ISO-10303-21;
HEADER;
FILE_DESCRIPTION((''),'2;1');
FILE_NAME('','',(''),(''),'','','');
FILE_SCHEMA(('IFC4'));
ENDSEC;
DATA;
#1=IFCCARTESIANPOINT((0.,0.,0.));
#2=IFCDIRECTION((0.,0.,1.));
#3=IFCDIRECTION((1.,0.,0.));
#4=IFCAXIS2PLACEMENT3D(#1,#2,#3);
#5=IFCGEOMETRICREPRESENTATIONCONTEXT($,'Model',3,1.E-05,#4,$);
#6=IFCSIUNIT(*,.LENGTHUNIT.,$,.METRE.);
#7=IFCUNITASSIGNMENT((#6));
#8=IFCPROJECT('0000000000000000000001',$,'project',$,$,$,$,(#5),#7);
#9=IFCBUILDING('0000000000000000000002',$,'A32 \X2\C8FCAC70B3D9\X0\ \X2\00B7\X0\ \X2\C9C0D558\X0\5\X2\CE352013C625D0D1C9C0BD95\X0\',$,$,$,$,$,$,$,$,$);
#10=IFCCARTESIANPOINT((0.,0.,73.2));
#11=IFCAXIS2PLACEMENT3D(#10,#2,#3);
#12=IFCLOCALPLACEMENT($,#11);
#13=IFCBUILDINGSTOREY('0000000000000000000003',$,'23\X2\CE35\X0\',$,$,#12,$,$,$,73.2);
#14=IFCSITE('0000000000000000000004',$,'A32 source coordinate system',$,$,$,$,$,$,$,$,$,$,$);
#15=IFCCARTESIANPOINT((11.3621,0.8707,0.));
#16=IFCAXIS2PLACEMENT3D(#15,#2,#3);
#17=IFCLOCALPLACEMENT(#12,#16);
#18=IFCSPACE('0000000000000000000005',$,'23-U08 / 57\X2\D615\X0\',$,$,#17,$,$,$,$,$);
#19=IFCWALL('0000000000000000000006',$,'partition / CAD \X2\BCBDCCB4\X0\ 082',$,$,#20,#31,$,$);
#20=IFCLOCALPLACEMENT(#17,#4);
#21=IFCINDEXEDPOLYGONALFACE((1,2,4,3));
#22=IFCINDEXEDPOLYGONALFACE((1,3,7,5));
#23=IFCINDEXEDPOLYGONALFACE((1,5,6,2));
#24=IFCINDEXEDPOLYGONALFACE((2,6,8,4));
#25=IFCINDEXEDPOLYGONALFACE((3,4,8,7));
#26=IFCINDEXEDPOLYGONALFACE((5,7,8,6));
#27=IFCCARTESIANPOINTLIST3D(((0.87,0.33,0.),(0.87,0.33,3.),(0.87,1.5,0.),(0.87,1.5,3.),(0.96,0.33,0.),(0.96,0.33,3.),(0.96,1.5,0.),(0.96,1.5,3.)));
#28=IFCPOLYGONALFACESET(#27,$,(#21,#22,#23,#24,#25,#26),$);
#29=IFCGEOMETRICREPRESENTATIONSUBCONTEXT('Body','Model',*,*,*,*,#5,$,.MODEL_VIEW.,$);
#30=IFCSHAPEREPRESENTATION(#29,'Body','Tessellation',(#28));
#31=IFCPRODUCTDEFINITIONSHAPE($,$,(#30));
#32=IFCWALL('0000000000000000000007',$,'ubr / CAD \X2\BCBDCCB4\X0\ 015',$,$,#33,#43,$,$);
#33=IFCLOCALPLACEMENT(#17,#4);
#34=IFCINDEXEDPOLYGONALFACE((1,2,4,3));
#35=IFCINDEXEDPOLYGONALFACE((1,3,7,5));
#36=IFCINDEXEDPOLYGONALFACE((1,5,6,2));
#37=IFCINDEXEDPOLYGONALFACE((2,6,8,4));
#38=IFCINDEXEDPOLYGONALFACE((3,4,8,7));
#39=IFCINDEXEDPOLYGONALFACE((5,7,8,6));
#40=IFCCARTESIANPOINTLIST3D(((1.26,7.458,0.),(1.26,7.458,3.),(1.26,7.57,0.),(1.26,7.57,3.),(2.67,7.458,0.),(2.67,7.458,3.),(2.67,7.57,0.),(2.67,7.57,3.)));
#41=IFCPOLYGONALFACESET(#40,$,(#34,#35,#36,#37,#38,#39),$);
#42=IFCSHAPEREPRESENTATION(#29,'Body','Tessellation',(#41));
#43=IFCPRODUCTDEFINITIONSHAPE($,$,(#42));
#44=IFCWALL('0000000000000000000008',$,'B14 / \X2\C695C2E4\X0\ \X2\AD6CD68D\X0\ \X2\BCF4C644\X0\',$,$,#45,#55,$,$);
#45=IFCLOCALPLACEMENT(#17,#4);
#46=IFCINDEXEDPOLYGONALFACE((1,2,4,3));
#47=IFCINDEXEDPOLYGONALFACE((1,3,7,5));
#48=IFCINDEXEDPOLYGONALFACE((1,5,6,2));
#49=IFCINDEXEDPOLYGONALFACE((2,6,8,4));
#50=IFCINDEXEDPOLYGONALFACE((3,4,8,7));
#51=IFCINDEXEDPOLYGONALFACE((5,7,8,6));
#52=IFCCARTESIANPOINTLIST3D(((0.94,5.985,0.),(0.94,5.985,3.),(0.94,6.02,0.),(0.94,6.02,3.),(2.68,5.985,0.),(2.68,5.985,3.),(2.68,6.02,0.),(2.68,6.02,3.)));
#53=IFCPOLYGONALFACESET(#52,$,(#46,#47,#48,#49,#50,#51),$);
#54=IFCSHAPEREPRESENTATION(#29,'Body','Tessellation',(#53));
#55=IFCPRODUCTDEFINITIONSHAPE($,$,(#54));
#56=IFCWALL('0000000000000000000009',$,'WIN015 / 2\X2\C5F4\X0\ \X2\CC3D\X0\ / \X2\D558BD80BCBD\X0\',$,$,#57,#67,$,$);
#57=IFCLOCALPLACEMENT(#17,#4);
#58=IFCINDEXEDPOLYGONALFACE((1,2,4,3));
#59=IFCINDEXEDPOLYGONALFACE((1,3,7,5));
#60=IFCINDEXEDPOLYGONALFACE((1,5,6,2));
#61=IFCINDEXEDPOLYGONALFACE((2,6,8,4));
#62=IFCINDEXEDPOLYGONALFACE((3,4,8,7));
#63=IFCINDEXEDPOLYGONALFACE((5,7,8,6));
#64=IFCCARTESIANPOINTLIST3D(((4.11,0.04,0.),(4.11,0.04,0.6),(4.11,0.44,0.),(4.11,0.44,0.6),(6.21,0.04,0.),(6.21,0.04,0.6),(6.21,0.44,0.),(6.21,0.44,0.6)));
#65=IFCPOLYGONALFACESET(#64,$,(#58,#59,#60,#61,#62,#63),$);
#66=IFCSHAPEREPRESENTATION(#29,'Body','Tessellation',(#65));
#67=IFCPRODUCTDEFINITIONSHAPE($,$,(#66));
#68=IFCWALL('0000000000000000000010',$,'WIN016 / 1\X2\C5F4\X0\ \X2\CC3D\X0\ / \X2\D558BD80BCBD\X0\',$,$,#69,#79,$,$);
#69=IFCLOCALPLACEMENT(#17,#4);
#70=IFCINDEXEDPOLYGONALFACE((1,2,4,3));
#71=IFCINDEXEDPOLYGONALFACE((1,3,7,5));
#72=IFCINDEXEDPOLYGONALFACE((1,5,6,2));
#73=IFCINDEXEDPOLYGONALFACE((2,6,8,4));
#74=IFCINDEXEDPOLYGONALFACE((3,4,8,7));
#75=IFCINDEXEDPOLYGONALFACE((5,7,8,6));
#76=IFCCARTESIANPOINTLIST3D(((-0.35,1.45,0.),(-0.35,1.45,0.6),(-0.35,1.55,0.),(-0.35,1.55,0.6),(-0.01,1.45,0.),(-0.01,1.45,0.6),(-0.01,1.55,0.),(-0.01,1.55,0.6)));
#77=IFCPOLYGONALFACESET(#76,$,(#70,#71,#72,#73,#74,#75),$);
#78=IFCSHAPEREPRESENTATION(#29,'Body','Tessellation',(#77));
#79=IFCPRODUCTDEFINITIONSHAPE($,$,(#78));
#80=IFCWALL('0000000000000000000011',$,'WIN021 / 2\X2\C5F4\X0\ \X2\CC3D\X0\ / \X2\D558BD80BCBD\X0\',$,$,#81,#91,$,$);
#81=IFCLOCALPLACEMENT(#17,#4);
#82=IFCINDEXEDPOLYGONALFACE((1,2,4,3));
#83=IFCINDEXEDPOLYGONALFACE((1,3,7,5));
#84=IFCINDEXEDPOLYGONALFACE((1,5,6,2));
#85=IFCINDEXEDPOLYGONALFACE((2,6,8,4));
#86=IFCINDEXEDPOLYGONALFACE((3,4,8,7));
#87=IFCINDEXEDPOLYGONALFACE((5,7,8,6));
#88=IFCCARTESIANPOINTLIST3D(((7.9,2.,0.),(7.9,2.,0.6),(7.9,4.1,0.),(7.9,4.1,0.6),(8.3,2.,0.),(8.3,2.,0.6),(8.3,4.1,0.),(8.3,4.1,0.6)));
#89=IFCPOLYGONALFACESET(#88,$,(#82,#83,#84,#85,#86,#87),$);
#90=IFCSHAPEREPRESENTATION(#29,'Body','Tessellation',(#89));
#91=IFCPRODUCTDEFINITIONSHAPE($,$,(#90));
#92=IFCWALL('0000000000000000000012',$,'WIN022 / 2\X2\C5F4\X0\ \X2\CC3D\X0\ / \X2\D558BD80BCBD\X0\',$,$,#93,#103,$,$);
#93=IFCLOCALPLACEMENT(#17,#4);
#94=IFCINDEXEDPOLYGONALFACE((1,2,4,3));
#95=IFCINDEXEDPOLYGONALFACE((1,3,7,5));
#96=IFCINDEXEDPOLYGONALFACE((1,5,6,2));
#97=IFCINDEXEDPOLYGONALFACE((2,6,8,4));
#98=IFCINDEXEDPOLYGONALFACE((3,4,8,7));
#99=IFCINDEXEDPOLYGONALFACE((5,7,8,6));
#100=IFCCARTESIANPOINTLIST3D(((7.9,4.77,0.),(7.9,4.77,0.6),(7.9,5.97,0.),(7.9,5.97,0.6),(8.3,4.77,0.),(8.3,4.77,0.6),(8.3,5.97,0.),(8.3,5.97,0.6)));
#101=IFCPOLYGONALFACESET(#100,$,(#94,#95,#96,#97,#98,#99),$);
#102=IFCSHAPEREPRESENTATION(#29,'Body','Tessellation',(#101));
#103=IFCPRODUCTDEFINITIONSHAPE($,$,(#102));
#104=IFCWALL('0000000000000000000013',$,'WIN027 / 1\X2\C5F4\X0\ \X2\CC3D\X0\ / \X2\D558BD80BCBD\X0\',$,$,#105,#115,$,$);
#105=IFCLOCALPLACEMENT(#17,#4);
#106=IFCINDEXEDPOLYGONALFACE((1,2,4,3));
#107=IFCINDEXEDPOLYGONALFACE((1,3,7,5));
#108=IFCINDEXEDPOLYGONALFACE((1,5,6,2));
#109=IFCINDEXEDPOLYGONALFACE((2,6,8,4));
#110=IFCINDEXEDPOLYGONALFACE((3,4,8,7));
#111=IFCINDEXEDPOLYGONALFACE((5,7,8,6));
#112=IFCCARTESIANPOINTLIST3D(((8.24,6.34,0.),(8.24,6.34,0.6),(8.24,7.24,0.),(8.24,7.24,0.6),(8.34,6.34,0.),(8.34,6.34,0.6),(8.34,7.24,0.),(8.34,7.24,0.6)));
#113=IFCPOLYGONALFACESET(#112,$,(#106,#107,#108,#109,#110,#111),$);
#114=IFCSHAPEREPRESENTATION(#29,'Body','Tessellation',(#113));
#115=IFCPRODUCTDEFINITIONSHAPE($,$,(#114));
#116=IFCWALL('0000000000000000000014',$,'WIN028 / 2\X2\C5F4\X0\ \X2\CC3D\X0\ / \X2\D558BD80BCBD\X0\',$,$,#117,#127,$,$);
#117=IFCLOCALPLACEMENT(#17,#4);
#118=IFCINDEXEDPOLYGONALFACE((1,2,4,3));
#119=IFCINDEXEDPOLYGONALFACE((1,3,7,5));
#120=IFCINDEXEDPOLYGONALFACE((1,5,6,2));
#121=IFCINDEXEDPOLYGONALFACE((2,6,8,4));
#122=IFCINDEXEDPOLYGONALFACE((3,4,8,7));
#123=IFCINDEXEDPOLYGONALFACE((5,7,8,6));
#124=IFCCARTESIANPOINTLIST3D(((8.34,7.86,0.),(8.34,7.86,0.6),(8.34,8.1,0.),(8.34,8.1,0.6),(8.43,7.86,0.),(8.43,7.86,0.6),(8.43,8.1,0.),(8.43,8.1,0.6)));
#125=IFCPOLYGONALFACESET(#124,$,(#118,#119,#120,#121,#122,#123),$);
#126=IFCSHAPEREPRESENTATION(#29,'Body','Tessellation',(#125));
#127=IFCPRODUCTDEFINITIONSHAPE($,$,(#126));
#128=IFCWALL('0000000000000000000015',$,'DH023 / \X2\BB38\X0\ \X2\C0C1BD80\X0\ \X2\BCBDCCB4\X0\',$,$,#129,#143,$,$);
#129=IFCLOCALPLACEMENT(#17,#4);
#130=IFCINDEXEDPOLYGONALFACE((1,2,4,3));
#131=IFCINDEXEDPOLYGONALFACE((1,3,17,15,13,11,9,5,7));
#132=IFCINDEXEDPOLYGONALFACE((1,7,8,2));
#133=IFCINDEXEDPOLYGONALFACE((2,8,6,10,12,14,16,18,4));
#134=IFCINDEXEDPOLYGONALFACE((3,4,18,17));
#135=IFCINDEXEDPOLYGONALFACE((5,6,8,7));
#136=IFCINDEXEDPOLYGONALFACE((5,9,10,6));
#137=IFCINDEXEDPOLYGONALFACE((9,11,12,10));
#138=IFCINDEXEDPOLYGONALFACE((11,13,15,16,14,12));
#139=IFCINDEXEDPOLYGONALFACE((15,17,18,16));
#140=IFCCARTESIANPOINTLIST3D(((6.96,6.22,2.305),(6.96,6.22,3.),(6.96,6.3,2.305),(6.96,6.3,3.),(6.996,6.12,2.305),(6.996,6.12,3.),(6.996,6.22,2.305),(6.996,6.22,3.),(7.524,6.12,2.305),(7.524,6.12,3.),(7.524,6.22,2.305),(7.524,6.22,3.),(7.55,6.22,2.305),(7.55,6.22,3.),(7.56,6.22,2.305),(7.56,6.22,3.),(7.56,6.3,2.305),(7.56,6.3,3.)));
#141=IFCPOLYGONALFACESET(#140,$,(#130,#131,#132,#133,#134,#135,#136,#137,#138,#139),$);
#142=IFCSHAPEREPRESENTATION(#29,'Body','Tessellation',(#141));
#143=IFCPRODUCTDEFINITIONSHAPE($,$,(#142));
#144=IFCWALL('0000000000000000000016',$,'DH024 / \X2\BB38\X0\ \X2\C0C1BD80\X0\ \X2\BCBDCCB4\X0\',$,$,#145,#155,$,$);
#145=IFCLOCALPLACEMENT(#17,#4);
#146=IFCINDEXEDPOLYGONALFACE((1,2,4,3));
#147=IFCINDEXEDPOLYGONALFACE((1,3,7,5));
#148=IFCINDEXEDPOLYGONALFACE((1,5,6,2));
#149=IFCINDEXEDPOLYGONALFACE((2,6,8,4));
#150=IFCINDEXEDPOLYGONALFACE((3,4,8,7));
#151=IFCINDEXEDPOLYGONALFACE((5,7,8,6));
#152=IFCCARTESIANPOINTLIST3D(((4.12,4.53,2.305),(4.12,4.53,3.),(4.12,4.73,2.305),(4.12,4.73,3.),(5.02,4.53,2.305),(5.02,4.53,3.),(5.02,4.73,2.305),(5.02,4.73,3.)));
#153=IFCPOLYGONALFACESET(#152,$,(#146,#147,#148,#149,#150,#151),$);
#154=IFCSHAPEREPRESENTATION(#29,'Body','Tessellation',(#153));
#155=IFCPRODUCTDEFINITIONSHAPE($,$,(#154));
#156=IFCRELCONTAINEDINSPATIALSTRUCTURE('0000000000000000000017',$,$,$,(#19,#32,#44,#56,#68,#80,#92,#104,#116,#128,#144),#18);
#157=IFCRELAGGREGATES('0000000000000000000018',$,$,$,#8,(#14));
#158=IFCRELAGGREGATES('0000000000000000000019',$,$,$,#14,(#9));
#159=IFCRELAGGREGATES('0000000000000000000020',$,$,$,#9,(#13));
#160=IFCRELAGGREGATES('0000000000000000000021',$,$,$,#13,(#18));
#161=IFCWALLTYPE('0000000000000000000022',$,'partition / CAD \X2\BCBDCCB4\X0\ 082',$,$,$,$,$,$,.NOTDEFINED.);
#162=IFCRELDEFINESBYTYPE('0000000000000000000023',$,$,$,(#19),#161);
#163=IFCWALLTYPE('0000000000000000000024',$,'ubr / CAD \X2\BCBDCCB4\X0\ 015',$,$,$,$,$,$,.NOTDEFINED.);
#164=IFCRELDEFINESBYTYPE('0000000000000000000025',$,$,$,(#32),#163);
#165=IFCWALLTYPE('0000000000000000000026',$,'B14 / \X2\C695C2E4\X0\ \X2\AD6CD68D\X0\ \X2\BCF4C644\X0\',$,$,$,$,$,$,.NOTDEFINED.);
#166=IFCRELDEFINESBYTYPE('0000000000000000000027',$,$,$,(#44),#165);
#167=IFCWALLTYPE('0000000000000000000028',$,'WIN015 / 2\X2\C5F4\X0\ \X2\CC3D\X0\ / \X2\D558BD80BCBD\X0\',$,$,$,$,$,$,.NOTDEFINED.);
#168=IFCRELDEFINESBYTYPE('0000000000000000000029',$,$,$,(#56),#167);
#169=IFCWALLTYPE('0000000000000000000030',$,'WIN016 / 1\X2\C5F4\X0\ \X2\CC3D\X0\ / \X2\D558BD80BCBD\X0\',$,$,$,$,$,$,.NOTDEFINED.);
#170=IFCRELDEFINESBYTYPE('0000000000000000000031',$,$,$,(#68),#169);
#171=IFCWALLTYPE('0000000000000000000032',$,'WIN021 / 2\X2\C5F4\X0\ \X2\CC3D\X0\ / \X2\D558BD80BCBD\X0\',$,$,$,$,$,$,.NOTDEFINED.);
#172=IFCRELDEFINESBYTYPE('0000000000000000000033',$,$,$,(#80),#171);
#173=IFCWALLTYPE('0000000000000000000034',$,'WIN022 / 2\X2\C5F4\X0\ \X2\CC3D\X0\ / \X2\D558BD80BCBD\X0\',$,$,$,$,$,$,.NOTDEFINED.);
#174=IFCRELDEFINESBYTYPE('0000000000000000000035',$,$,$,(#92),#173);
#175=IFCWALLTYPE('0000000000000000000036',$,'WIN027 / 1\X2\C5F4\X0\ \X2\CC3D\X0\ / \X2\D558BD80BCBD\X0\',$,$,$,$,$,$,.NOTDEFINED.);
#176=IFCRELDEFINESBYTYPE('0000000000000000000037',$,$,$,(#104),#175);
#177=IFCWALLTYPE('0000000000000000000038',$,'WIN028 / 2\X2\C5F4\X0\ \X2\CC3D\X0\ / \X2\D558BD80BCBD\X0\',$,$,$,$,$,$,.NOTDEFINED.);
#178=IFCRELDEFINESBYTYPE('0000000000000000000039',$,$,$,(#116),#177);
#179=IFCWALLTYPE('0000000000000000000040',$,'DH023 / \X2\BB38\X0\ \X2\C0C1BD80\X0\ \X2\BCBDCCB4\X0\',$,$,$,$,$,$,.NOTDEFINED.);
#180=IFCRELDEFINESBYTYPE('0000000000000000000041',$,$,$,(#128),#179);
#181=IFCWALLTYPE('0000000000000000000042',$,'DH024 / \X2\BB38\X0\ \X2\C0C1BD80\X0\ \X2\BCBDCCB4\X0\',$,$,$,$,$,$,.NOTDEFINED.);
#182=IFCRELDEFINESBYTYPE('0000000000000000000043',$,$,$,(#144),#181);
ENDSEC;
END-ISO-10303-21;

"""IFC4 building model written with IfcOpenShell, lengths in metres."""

from ifc_helpers import new_model, si_unit, frame, origin, origin_with_axes, place, context, subcontext, project, spatial, polyline, outline, extrude, source, transform, mapped, type_object, type_shapes, element, save


model = new_model("IFC4")

# Units and contexts
model_context = context("Model", 3, precision=1e-05, world=origin_with_axes())
body_context = subcontext(model_context, "Body", "Model", "MODEL_VIEW")
ifc_project = project(units=[si_unit("LENGTHUNIT", "METRE")], contexts=[model_context])

# Site, building, storey, space
site = spatial("IfcSite", under=ifc_project, Name="A32 source coordinate system")
building = spatial("IfcBuilding", under=site, Name="A32 주거동 · 지하5층–옥탑지붕")
storey_placement = place(None, frame((0.0, 0.0, 73.2), z_axis=(0.0, 0.0, 1.0), x_axis=(1.0, 0.0, 0.0)))
storey = spatial("IfcBuildingStorey", under=building, at=storey_placement, Name="23층", Elevation=73.2)
space_placement = place(storey_placement, frame((11.3621, 0.8707, 0.0), z_axis=(0.0, 0.0, 1.0), x_axis=(1.0, 0.0, 0.0)))
space = spatial("IfcSpace", under=storey, at=space_placement, Name="23-U08 / 57형")

# Walls
wall_type_1 = type_object("IfcWallType", Name="partition / CAD 벽체 082", PredefinedType="NOTDEFINED")
shared_shape_1 = source(origin(), body_context, "Body", "SweptSolid", [
    extrude(outline(polyline([(0.96, 0.33), (0.87, 0.33), (0.87, 1.5), (0.96, 1.5), (0.96, 0.33)])), origin(), (0.0, 0.0, 1.0), 3.0),
])
type_shapes(wall_type_1, [shared_shape_1])
wall_1_placement = place(space_placement, origin_with_axes())
element("IfcWall", 1, at=wall_1_placement, inside=space, type_object=wall_type_1, Name="partition / CAD 벽체 082", context=body_context, shape_type="MappedRepresentation", body=[
    mapped(shared_shape_1, transform((0.0, 0.0, 0.0), scale=1.0)),
])
wall_type_2 = type_object("IfcWallType", Name="ubr / CAD 벽체 015", PredefinedType="NOTDEFINED")
shared_shape_2 = source(origin(), body_context, "Body", "SweptSolid", [
    extrude(outline(polyline([(2.67, 7.57), (2.67, 7.458), (1.26, 7.458), (1.26, 7.57), (2.67, 7.57)])), origin(), (0.0, 0.0, 1.0), 3.0),
])
type_shapes(wall_type_2, [shared_shape_2])
wall_2_placement = place(space_placement, origin_with_axes())
element("IfcWall", 2, at=wall_2_placement, inside=space, type_object=wall_type_2, Name="ubr / CAD 벽체 015", context=body_context, shape_type="MappedRepresentation", body=[
    mapped(shared_shape_2, transform((0.0, 0.0, 0.0), scale=1.0)),
])
wall_type_3 = type_object("IfcWallType", Name="B14 / 욕실 구획 보완", PredefinedType="NOTDEFINED")
shared_shape_3 = source(origin(), body_context, "Body", "SweptSolid", [
    extrude(outline(polyline([(2.68, 5.985), (0.94, 5.985), (0.94, 6.02), (2.68, 6.02), (2.68, 5.985)])), origin(), (0.0, 0.0, 1.0), 3.0),
])
type_shapes(wall_type_3, [shared_shape_3])
wall_3_placement = place(space_placement, origin_with_axes())
element("IfcWall", 3, at=wall_3_placement, inside=space, type_object=wall_type_3, Name="B14 / 욕실 구획 보완", context=body_context, shape_type="MappedRepresentation", body=[
    mapped(shared_shape_3, transform((0.0, 0.0, 0.0), scale=1.0)),
])
wall_type_4 = type_object("IfcWallType", Name="WIN015 / 2열 창 / 하부벽", PredefinedType="NOTDEFINED")
shared_shape_4 = source(origin(), body_context, "Body", "SweptSolid", [
    extrude(outline(polyline([(4.11, 0.04), (4.11, 0.44), (6.21, 0.44), (6.21, 0.04), (4.11, 0.04)])), origin(), (0.0, 0.0, 1.0), 0.6),
])
type_shapes(wall_type_4, [shared_shape_4])
wall_4_placement = place(space_placement, origin_with_axes())
element("IfcWall", 4, at=wall_4_placement, inside=space, type_object=wall_type_4, Name="WIN015 / 2열 창 / 하부벽", context=body_context, shape_type="MappedRepresentation", body=[
    mapped(shared_shape_4, transform((0.0, 0.0, 0.0), scale=1.0)),
])
wall_type_5 = type_object("IfcWallType", Name="WIN016 / 1열 창 / 하부벽", PredefinedType="NOTDEFINED")
shared_shape_5 = source(origin(), body_context, "Body", "SweptSolid", [
    extrude(outline(polyline([(-0.35, 1.45), (-0.35, 1.55), (-0.01, 1.55), (-0.01, 1.45), (-0.35, 1.45)])), origin(), (0.0, 0.0, 1.0), 0.6),
])
type_shapes(wall_type_5, [shared_shape_5])
wall_5_placement = place(space_placement, origin_with_axes())
element("IfcWall", 5, at=wall_5_placement, inside=space, type_object=wall_type_5, Name="WIN016 / 1열 창 / 하부벽", context=body_context, shape_type="MappedRepresentation", body=[
    mapped(shared_shape_5, transform((0.0, 0.0, 0.0), scale=1.0)),
])
wall_type_6 = type_object("IfcWallType", Name="WIN021 / 2열 창 / 하부벽", PredefinedType="NOTDEFINED")
shared_shape_6 = source(origin(), body_context, "Body", "SweptSolid", [
    extrude(outline(polyline([(7.9, 2.0), (7.9, 4.1), (8.3, 4.1), (8.3, 2.0), (7.9, 2.0)])), origin(), (0.0, 0.0, 1.0), 0.6),
])
type_shapes(wall_type_6, [shared_shape_6])
wall_6_placement = place(space_placement, origin_with_axes())
element("IfcWall", 6, at=wall_6_placement, inside=space, type_object=wall_type_6, Name="WIN021 / 2열 창 / 하부벽", context=body_context, shape_type="MappedRepresentation", body=[
    mapped(shared_shape_6, transform((0.0, 0.0, 0.0), scale=1.0)),
])
wall_type_7 = type_object("IfcWallType", Name="WIN022 / 2열 창 / 하부벽", PredefinedType="NOTDEFINED")
shared_shape_7 = source(origin(), body_context, "Body", "SweptSolid", [
    extrude(outline(polyline([(7.9, 4.77), (7.9, 5.97), (8.3, 5.97), (8.3, 4.77), (7.9, 4.77)])), origin(), (0.0, 0.0, 1.0), 0.6),
])
type_shapes(wall_type_7, [shared_shape_7])
wall_7_placement = place(space_placement, origin_with_axes())
element("IfcWall", 7, at=wall_7_placement, inside=space, type_object=wall_type_7, Name="WIN022 / 2열 창 / 하부벽", context=body_context, shape_type="MappedRepresentation", body=[
    mapped(shared_shape_7, transform((0.0, 0.0, 0.0), scale=1.0)),
])
wall_type_8 = type_object("IfcWallType", Name="WIN027 / 1열 창 / 하부벽", PredefinedType="NOTDEFINED")
shared_shape_8 = source(origin(), body_context, "Body", "SweptSolid", [
    extrude(outline(polyline([(8.24, 6.34), (8.24, 7.24), (8.34, 7.24), (8.34, 6.34), (8.24, 6.34)])), origin(), (0.0, 0.0, 1.0), 0.6),
])
type_shapes(wall_type_8, [shared_shape_8])
wall_8_placement = place(space_placement, origin_with_axes())
element("IfcWall", 8, at=wall_8_placement, inside=space, type_object=wall_type_8, Name="WIN027 / 1열 창 / 하부벽", context=body_context, shape_type="MappedRepresentation", body=[
    mapped(shared_shape_8, transform((0.0, 0.0, 0.0), scale=1.0)),
])
wall_type_9 = type_object("IfcWallType", Name="WIN028 / 2열 창 / 하부벽", PredefinedType="NOTDEFINED")
shared_shape_9 = source(origin(), body_context, "Body", "SweptSolid", [
    extrude(outline(polyline([(8.34, 7.86), (8.34, 8.1), (8.43, 8.1), (8.43, 7.86), (8.34, 7.86)])), origin(), (0.0, 0.0, 1.0), 0.6),
])
type_shapes(wall_type_9, [shared_shape_9])
wall_9_placement = place(space_placement, origin_with_axes())
element("IfcWall", 9, at=wall_9_placement, inside=space, type_object=wall_type_9, Name="WIN028 / 2열 창 / 하부벽", context=body_context, shape_type="MappedRepresentation", body=[
    mapped(shared_shape_9, transform((0.0, 0.0, 0.0), scale=1.0)),
])
wall_type_10 = type_object("IfcWallType", Name="DH023 / 문 상부 벽체", PredefinedType="NOTDEFINED")
shared_shape_10 = source(origin(), body_context, "Body", "SweptSolid", [
    extrude(outline(polyline([(6.96, 6.3), (7.56, 6.3), (7.56, 6.22), (7.55, 6.22), (7.524, 6.22), (7.524, 6.12), (6.996, 6.12), (6.996, 6.22), (6.96, 6.22), (6.96, 6.3)])), frame((0.0, 0.0, 2.305)), (0.0, 0.0, 1.0), 0.695),
])
type_shapes(wall_type_10, [shared_shape_10])
wall_10_placement = place(space_placement, origin_with_axes())
element("IfcWall", 10, at=wall_10_placement, inside=space, type_object=wall_type_10, Name="DH023 / 문 상부 벽체", context=body_context, shape_type="MappedRepresentation", body=[
    mapped(shared_shape_10, transform((0.0, 0.0, 0.0), scale=1.0)),
])
wall_type_11 = type_object("IfcWallType", Name="DH024 / 문 상부 벽체", PredefinedType="NOTDEFINED")
shared_shape_11 = source(origin(), body_context, "Body", "SweptSolid", [
    extrude(outline(polyline([(4.12, 4.73), (5.02, 4.73), (5.02, 4.53), (4.12, 4.53), (4.12, 4.73)])), frame((0.0, 0.0, 2.305)), (0.0, 0.0, 1.0), 0.695),
])
type_shapes(wall_type_11, [shared_shape_11])
wall_11_placement = place(space_placement, origin_with_axes())
element("IfcWall", 11, at=wall_11_placement, inside=space, type_object=wall_type_11, Name="DH024 / 문 상부 벽체", context=body_context, shape_type="MappedRepresentation", body=[
    mapped(shared_shape_11, transform((0.0, 0.0, 0.0), scale=1.0)),
])

save(model, "model.ifc")
